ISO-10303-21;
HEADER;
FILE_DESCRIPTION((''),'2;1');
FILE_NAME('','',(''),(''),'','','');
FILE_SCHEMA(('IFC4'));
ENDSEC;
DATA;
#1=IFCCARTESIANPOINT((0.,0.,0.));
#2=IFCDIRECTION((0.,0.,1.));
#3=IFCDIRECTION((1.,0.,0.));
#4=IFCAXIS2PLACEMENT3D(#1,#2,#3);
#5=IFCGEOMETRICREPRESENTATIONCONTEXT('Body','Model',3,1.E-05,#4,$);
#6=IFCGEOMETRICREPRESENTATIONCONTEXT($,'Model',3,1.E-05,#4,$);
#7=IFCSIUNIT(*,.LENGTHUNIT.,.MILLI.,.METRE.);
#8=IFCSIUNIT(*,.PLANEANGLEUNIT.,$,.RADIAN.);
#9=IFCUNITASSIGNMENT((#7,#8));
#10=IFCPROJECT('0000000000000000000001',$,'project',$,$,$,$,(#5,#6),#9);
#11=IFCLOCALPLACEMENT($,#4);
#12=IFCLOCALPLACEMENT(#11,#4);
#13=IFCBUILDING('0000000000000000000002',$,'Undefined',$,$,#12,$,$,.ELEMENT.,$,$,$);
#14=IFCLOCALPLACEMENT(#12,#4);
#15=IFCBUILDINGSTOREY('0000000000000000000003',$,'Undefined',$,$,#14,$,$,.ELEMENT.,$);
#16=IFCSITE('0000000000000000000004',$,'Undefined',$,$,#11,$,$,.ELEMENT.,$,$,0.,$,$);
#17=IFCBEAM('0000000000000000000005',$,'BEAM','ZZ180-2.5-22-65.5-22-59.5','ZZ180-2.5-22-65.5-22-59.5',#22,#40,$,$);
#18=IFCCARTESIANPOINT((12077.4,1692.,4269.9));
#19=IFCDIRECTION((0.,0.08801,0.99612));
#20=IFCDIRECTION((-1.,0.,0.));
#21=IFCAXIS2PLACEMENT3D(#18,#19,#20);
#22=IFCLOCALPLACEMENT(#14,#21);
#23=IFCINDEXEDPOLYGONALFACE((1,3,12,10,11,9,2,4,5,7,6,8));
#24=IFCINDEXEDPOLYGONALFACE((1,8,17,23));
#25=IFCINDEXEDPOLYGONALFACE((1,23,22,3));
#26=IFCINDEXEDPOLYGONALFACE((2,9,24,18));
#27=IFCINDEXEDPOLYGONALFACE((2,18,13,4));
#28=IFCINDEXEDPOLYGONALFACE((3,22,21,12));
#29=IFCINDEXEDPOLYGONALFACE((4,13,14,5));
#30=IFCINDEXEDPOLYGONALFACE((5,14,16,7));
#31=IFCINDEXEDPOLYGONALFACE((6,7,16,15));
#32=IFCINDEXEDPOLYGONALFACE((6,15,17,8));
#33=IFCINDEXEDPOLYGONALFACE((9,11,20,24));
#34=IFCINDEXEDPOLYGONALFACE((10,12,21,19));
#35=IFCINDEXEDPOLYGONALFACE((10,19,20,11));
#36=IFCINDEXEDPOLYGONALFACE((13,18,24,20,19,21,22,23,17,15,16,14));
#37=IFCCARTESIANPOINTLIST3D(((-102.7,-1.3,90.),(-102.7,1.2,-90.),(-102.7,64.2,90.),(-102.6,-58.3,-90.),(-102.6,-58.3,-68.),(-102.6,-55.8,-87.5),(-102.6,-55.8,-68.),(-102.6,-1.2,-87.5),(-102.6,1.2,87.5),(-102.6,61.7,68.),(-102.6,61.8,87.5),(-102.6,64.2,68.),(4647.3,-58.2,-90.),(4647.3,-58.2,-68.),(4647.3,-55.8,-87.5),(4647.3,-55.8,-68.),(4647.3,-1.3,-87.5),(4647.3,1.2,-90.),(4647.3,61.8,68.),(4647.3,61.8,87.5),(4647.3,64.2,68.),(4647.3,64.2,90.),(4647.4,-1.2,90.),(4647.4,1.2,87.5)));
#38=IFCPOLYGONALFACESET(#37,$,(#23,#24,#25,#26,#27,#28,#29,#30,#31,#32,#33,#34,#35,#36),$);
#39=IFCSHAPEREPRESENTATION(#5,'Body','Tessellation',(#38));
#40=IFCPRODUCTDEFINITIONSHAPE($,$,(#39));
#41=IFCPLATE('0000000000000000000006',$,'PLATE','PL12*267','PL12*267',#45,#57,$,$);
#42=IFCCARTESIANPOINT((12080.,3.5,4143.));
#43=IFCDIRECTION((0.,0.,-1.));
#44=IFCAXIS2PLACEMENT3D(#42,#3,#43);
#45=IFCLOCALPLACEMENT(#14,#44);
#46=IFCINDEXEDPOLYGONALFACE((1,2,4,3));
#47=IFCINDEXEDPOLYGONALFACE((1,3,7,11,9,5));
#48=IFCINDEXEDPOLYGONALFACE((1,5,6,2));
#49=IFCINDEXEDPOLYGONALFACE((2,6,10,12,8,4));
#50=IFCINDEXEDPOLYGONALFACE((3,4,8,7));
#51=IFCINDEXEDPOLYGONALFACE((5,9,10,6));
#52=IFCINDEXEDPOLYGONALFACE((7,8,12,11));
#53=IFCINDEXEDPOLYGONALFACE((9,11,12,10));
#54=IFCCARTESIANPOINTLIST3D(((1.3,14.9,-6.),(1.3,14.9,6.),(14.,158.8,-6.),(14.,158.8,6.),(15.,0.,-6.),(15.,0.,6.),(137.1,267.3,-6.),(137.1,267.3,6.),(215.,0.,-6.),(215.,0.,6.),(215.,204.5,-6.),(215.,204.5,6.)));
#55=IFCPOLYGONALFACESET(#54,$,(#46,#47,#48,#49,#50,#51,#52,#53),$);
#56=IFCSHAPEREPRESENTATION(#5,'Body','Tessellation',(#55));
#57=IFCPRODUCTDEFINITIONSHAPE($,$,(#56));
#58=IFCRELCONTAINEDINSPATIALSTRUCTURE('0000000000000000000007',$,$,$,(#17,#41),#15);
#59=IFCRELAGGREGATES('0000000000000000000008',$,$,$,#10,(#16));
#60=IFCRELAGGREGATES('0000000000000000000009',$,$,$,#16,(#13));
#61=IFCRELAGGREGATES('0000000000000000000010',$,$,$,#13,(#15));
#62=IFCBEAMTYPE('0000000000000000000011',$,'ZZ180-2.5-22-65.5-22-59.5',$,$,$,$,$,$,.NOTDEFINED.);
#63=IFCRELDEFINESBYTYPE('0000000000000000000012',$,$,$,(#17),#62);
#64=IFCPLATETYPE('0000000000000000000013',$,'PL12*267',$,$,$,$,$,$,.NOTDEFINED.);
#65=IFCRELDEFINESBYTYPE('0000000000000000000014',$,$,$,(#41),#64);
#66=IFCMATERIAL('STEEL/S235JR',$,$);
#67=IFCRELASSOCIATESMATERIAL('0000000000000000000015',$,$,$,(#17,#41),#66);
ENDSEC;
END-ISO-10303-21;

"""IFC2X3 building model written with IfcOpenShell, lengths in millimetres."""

from ifc_helpers import new_model, si_unit, frame, origin_with_axes, place, context, project, spatial, polyline, outline, extrude, material, type_object, element, save


model = new_model("IFC2X3")

# Units and contexts
model_context_1 = context("Model", 3, precision=1e-05, world=origin_with_axes(), identifier="Body")
model_context_2 = context("Model", 3, precision=1e-05, world=origin_with_axes())
ifc_project = project(units=[si_unit("LENGTHUNIT", "METRE", prefix="MILLI"), si_unit("PLANEANGLEUNIT", "RADIAN")], contexts=[model_context_1, model_context_2])

# Site, building, storey
site_placement = place(None, origin_with_axes())
site = spatial("IfcSite", under=ifc_project, at=site_placement, Name="Undefined", CompositionType="ELEMENT", RefElevation=0.0)
building_placement = place(site_placement, origin_with_axes())
building = spatial("IfcBuilding", under=site, at=building_placement, Name="Undefined", CompositionType="ELEMENT")
storey_placement = place(building_placement, origin_with_axes())
storey = spatial("IfcBuildingStorey", under=building, at=storey_placement, Name="Undefined", CompositionType="ELEMENT")

# Shared definitions
ifc_material = material(Name="STEEL/S235JR")

# Beam
beam_type_1 = type_object("IfcBeamType", Name="ZZ180-2.5-22-65.5-22-59.5", PredefinedType="NOTDEFINED")
beam_1_placement = place(storey_placement, frame((12077.4, 1692.0, 4269.9), z_axis=(0.0, 0.08801, 0.99612), x_axis=(-1.0, 0.0, 0.0)))
element("IfcBeam", 1, at=beam_1_placement, inside=storey, type_object=beam_type_1, material=ifc_material, Name="BEAM", Description="ZZ180-2.5-22-65.5-22-59.5", ObjectType="ZZ180-2.5-22-65.5-22-59.5", context=model_context_1, shape_type="SweptSolid", body=[
    extrude(outline(polyline([(58.2, -90.0), (58.2, -68.0), (55.8, -68.0), (55.8, -87.5), (1.2, -87.5), (1.2, 90.0), (-64.2, 90.0), (-64.2, 68.0), (-61.8, 68.0), (-61.8, 87.5), (-1.2, 87.5), (-1.2, -90.0), (58.2, -90.0)])), frame((4647.4, 0.0, 0.0), z_axis=(-1.0, 0.0, 0.0), x_axis=(0.0, -1.0, 0.0)), (0.0, 0.0, 1.0), 4750.0),
])

# Plate
plate_type_1 = type_object("IfcPlateType", Name="PL12*267", PredefinedType="NOTDEFINED")
plate_1_placement = place(storey_placement, frame((12080.0, 3.5, 4143.0), z_axis=(1.0, 0.0, 0.0), x_axis=(0.0, 0.0, -1.0)))
element("IfcPlate", 2, at=plate_1_placement, inside=storey, type_object=plate_type_1, material=ifc_material, Name="PLATE", Description="PL12*267", ObjectType="PL12*267", context=model_context_1, shape_type="SweptSolid", body=[
    extrude(outline(polyline([(1.3, 14.9), (15.0, 0.0), (215.0, 0.0), (215.0, 204.5), (137.1, 267.3), (14.0, 158.8), (1.3, 14.9)])), frame((0.0, 0.0, -6.0), z_axis=(0.0, 0.0, 1.0), x_axis=(1.0, 0.0, 0.0)), (0.0, 0.0, 1.0), 12.0),
])

save(model, "model.ifc")
